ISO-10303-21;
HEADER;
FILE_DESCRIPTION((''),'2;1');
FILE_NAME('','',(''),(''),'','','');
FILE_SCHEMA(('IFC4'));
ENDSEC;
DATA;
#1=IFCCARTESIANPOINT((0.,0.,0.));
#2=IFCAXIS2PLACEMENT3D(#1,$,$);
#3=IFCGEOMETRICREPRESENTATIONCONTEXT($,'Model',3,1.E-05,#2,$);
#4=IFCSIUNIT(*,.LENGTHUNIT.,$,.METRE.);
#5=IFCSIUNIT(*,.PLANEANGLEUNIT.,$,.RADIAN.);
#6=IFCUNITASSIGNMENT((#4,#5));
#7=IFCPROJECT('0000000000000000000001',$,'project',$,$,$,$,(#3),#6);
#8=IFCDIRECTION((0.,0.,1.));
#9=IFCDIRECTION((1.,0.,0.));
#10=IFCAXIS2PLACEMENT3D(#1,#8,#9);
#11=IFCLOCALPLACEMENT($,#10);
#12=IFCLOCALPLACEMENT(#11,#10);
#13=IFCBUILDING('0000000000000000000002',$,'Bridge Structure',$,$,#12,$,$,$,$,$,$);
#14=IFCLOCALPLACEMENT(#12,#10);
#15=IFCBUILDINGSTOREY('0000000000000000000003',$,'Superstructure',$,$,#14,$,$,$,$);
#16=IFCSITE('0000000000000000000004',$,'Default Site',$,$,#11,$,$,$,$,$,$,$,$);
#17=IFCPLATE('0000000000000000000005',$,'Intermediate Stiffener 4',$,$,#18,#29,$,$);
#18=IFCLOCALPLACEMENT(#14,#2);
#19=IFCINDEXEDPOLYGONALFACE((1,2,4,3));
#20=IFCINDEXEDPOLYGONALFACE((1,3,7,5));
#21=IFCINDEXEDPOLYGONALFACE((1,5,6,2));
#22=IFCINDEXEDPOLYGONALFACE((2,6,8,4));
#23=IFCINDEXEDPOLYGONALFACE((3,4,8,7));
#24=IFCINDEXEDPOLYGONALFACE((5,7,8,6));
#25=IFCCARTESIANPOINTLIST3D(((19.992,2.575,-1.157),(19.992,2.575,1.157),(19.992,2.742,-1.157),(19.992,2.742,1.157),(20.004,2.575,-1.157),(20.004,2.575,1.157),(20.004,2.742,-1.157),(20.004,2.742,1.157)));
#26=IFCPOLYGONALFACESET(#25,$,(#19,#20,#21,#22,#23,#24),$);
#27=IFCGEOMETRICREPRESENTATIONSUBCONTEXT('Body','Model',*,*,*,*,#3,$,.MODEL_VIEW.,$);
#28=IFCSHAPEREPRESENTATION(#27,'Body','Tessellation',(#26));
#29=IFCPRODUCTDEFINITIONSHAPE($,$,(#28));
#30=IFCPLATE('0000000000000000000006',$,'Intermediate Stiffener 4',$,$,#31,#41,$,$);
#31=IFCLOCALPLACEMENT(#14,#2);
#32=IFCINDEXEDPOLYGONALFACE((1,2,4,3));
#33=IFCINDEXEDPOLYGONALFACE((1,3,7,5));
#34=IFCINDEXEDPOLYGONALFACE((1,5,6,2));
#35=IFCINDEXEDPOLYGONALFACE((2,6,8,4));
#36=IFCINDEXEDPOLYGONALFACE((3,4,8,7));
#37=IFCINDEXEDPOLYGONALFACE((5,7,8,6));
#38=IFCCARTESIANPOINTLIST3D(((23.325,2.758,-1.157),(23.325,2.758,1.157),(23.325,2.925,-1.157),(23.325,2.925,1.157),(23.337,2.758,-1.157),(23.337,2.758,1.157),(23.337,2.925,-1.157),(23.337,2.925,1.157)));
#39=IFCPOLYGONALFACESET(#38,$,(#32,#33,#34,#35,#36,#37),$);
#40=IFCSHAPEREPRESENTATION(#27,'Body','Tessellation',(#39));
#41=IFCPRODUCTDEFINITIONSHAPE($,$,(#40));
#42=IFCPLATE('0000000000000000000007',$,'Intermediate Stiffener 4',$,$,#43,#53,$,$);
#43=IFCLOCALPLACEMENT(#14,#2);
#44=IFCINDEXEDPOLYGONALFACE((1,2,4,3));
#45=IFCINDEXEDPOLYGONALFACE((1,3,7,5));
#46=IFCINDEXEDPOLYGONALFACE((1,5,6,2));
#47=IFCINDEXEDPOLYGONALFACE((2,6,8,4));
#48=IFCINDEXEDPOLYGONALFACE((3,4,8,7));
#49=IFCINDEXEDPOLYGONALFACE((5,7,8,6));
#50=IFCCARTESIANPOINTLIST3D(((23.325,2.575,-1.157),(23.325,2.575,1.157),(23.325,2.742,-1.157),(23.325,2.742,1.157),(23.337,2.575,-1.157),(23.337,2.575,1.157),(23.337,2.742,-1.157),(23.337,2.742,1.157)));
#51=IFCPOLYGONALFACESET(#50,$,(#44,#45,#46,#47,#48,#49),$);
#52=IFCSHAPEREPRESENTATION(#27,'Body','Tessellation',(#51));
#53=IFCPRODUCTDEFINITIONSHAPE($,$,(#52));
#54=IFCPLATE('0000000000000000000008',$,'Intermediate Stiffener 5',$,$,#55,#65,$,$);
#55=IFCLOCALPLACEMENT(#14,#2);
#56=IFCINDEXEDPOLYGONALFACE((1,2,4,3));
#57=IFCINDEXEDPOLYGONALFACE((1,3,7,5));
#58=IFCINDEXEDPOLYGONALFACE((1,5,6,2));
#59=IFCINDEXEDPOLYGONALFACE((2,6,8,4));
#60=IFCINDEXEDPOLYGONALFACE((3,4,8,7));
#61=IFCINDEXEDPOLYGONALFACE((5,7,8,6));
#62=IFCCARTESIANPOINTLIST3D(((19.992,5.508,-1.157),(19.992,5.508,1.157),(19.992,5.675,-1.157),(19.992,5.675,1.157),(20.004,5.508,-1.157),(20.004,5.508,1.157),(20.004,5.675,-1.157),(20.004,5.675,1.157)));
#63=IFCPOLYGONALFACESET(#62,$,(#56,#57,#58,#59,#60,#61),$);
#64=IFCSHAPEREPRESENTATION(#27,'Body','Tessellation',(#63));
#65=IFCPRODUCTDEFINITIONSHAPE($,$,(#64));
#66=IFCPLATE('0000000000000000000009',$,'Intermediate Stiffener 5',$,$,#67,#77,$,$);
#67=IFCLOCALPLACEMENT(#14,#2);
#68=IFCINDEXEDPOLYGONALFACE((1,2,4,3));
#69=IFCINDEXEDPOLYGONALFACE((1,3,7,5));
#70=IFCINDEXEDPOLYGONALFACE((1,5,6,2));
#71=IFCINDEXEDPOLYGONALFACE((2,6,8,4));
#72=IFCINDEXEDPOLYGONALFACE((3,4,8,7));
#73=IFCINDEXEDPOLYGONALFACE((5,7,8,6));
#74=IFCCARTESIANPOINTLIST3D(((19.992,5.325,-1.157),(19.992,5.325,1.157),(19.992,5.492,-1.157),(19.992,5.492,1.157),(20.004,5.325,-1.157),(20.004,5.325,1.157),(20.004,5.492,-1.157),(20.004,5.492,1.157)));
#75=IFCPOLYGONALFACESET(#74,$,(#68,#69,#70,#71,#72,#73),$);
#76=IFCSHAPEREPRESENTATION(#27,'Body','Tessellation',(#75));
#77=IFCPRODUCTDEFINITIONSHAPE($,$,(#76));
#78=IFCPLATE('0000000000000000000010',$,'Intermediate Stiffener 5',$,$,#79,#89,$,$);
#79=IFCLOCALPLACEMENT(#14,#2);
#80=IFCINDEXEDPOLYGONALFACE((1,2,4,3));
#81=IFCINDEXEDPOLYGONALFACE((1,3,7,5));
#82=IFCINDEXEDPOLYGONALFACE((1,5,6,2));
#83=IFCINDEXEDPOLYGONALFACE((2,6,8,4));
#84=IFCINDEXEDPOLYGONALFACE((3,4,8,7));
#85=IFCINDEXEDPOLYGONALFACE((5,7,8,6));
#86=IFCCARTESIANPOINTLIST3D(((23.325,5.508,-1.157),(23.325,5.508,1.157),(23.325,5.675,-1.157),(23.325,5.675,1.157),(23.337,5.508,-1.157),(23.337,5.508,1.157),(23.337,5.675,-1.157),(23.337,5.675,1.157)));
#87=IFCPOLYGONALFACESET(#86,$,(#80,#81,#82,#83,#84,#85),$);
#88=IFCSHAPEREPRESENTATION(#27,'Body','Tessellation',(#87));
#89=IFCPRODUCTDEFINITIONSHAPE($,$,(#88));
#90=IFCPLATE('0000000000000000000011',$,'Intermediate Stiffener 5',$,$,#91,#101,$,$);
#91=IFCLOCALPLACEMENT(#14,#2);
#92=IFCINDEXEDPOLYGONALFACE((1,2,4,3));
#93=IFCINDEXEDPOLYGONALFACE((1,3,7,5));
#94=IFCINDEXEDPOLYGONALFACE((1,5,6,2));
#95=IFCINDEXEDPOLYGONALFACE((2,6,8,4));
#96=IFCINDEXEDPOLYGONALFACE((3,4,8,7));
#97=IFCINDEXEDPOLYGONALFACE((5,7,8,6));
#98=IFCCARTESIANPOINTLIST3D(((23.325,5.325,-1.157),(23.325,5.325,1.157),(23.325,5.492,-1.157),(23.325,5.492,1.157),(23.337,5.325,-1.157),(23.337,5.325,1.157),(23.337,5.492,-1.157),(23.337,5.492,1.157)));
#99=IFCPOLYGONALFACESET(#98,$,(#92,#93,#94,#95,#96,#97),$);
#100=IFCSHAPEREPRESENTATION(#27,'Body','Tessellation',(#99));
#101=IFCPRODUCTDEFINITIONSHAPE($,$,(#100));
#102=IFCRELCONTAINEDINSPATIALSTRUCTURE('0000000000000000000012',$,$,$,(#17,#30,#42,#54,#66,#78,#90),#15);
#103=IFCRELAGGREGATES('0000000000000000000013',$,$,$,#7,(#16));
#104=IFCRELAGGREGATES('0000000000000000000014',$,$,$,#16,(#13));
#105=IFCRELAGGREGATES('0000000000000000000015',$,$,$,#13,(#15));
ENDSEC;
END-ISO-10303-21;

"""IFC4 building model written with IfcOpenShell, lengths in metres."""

from ifc_helpers import new_model, si_unit, frame, origin, origin_with_axes, origin_2d_with_axis, place, context, subcontext, project, spatial, rectangle, extrude, element, save


model = new_model("IFC4")

# Units and contexts
model_context = context("Model", 3, precision=1e-05, world=origin())
body_context = subcontext(model_context, "Body", "Model", "MODEL_VIEW")
ifc_project = project(units=[si_unit("LENGTHUNIT", "METRE"), si_unit("PLANEANGLEUNIT", "RADIAN")], contexts=[model_context])

# Site, building, storey
site_placement = place(None, origin_with_axes())
site = spatial("IfcSite", under=ifc_project, at=site_placement, Name="Default Site")
building_placement = place(site_placement, origin_with_axes())
building = spatial("IfcBuilding", under=site, at=building_placement, Name="Bridge Structure")
storey_placement = place(building_placement, origin_with_axes())
storey = spatial("IfcBuildingStorey", under=building, at=storey_placement, Name="Superstructure")

# Plates
for number, where, z_axis, x_axis, name in (
    (1, (19.998, 2.6585, -1.157), (0.0, 0.0, 1.0), (1.0, 0.0, 0.0), "Intermediate Stiffener 4"),
    (2, (23.331, 2.8415, -1.157), (0.0, 0.0, 1.0), (1.0, 0.0, 0.0), "Intermediate Stiffener 4"),
    (3, (23.331, 2.6585, -1.157), (0.0, 0.0, 1.0), (1.0, 0.0, 0.0), "Intermediate Stiffener 4"),
    (4, (19.998, 5.5915, -1.157), (0.0, 0.0, 1.0), (1.0, 0.0, 0.0), "Intermediate Stiffener 5"),
    (5, (19.998, 5.4085, -1.157), (0.0, 0.0, 1.0), (1.0, 0.0, 0.0), "Intermediate Stiffener 5"),
    (6, (23.331, 5.5915, -1.157), (0.0, 0.0, 1.0), (1.0, 0.0, 0.0), "Intermediate Stiffener 5"),
    (7, (23.331, 5.4085, -1.157), (0.0, 0.0, 1.0), (1.0, 0.0, 0.0), "Intermediate Stiffener 5"),
):
    element("IfcPlate", number, at=place(storey_placement, frame(where, z_axis=z_axis, x_axis=x_axis)), inside=storey, Name=name, context=body_context, shape_type="SweptSolid", body=[
        extrude(rectangle(XDim=0.012, YDim=0.167, at=origin_2d_with_axis()), origin_with_axes(), (0.0, 0.0, 1.0), 2.314),
    ])

save(model, "model.ifc")
